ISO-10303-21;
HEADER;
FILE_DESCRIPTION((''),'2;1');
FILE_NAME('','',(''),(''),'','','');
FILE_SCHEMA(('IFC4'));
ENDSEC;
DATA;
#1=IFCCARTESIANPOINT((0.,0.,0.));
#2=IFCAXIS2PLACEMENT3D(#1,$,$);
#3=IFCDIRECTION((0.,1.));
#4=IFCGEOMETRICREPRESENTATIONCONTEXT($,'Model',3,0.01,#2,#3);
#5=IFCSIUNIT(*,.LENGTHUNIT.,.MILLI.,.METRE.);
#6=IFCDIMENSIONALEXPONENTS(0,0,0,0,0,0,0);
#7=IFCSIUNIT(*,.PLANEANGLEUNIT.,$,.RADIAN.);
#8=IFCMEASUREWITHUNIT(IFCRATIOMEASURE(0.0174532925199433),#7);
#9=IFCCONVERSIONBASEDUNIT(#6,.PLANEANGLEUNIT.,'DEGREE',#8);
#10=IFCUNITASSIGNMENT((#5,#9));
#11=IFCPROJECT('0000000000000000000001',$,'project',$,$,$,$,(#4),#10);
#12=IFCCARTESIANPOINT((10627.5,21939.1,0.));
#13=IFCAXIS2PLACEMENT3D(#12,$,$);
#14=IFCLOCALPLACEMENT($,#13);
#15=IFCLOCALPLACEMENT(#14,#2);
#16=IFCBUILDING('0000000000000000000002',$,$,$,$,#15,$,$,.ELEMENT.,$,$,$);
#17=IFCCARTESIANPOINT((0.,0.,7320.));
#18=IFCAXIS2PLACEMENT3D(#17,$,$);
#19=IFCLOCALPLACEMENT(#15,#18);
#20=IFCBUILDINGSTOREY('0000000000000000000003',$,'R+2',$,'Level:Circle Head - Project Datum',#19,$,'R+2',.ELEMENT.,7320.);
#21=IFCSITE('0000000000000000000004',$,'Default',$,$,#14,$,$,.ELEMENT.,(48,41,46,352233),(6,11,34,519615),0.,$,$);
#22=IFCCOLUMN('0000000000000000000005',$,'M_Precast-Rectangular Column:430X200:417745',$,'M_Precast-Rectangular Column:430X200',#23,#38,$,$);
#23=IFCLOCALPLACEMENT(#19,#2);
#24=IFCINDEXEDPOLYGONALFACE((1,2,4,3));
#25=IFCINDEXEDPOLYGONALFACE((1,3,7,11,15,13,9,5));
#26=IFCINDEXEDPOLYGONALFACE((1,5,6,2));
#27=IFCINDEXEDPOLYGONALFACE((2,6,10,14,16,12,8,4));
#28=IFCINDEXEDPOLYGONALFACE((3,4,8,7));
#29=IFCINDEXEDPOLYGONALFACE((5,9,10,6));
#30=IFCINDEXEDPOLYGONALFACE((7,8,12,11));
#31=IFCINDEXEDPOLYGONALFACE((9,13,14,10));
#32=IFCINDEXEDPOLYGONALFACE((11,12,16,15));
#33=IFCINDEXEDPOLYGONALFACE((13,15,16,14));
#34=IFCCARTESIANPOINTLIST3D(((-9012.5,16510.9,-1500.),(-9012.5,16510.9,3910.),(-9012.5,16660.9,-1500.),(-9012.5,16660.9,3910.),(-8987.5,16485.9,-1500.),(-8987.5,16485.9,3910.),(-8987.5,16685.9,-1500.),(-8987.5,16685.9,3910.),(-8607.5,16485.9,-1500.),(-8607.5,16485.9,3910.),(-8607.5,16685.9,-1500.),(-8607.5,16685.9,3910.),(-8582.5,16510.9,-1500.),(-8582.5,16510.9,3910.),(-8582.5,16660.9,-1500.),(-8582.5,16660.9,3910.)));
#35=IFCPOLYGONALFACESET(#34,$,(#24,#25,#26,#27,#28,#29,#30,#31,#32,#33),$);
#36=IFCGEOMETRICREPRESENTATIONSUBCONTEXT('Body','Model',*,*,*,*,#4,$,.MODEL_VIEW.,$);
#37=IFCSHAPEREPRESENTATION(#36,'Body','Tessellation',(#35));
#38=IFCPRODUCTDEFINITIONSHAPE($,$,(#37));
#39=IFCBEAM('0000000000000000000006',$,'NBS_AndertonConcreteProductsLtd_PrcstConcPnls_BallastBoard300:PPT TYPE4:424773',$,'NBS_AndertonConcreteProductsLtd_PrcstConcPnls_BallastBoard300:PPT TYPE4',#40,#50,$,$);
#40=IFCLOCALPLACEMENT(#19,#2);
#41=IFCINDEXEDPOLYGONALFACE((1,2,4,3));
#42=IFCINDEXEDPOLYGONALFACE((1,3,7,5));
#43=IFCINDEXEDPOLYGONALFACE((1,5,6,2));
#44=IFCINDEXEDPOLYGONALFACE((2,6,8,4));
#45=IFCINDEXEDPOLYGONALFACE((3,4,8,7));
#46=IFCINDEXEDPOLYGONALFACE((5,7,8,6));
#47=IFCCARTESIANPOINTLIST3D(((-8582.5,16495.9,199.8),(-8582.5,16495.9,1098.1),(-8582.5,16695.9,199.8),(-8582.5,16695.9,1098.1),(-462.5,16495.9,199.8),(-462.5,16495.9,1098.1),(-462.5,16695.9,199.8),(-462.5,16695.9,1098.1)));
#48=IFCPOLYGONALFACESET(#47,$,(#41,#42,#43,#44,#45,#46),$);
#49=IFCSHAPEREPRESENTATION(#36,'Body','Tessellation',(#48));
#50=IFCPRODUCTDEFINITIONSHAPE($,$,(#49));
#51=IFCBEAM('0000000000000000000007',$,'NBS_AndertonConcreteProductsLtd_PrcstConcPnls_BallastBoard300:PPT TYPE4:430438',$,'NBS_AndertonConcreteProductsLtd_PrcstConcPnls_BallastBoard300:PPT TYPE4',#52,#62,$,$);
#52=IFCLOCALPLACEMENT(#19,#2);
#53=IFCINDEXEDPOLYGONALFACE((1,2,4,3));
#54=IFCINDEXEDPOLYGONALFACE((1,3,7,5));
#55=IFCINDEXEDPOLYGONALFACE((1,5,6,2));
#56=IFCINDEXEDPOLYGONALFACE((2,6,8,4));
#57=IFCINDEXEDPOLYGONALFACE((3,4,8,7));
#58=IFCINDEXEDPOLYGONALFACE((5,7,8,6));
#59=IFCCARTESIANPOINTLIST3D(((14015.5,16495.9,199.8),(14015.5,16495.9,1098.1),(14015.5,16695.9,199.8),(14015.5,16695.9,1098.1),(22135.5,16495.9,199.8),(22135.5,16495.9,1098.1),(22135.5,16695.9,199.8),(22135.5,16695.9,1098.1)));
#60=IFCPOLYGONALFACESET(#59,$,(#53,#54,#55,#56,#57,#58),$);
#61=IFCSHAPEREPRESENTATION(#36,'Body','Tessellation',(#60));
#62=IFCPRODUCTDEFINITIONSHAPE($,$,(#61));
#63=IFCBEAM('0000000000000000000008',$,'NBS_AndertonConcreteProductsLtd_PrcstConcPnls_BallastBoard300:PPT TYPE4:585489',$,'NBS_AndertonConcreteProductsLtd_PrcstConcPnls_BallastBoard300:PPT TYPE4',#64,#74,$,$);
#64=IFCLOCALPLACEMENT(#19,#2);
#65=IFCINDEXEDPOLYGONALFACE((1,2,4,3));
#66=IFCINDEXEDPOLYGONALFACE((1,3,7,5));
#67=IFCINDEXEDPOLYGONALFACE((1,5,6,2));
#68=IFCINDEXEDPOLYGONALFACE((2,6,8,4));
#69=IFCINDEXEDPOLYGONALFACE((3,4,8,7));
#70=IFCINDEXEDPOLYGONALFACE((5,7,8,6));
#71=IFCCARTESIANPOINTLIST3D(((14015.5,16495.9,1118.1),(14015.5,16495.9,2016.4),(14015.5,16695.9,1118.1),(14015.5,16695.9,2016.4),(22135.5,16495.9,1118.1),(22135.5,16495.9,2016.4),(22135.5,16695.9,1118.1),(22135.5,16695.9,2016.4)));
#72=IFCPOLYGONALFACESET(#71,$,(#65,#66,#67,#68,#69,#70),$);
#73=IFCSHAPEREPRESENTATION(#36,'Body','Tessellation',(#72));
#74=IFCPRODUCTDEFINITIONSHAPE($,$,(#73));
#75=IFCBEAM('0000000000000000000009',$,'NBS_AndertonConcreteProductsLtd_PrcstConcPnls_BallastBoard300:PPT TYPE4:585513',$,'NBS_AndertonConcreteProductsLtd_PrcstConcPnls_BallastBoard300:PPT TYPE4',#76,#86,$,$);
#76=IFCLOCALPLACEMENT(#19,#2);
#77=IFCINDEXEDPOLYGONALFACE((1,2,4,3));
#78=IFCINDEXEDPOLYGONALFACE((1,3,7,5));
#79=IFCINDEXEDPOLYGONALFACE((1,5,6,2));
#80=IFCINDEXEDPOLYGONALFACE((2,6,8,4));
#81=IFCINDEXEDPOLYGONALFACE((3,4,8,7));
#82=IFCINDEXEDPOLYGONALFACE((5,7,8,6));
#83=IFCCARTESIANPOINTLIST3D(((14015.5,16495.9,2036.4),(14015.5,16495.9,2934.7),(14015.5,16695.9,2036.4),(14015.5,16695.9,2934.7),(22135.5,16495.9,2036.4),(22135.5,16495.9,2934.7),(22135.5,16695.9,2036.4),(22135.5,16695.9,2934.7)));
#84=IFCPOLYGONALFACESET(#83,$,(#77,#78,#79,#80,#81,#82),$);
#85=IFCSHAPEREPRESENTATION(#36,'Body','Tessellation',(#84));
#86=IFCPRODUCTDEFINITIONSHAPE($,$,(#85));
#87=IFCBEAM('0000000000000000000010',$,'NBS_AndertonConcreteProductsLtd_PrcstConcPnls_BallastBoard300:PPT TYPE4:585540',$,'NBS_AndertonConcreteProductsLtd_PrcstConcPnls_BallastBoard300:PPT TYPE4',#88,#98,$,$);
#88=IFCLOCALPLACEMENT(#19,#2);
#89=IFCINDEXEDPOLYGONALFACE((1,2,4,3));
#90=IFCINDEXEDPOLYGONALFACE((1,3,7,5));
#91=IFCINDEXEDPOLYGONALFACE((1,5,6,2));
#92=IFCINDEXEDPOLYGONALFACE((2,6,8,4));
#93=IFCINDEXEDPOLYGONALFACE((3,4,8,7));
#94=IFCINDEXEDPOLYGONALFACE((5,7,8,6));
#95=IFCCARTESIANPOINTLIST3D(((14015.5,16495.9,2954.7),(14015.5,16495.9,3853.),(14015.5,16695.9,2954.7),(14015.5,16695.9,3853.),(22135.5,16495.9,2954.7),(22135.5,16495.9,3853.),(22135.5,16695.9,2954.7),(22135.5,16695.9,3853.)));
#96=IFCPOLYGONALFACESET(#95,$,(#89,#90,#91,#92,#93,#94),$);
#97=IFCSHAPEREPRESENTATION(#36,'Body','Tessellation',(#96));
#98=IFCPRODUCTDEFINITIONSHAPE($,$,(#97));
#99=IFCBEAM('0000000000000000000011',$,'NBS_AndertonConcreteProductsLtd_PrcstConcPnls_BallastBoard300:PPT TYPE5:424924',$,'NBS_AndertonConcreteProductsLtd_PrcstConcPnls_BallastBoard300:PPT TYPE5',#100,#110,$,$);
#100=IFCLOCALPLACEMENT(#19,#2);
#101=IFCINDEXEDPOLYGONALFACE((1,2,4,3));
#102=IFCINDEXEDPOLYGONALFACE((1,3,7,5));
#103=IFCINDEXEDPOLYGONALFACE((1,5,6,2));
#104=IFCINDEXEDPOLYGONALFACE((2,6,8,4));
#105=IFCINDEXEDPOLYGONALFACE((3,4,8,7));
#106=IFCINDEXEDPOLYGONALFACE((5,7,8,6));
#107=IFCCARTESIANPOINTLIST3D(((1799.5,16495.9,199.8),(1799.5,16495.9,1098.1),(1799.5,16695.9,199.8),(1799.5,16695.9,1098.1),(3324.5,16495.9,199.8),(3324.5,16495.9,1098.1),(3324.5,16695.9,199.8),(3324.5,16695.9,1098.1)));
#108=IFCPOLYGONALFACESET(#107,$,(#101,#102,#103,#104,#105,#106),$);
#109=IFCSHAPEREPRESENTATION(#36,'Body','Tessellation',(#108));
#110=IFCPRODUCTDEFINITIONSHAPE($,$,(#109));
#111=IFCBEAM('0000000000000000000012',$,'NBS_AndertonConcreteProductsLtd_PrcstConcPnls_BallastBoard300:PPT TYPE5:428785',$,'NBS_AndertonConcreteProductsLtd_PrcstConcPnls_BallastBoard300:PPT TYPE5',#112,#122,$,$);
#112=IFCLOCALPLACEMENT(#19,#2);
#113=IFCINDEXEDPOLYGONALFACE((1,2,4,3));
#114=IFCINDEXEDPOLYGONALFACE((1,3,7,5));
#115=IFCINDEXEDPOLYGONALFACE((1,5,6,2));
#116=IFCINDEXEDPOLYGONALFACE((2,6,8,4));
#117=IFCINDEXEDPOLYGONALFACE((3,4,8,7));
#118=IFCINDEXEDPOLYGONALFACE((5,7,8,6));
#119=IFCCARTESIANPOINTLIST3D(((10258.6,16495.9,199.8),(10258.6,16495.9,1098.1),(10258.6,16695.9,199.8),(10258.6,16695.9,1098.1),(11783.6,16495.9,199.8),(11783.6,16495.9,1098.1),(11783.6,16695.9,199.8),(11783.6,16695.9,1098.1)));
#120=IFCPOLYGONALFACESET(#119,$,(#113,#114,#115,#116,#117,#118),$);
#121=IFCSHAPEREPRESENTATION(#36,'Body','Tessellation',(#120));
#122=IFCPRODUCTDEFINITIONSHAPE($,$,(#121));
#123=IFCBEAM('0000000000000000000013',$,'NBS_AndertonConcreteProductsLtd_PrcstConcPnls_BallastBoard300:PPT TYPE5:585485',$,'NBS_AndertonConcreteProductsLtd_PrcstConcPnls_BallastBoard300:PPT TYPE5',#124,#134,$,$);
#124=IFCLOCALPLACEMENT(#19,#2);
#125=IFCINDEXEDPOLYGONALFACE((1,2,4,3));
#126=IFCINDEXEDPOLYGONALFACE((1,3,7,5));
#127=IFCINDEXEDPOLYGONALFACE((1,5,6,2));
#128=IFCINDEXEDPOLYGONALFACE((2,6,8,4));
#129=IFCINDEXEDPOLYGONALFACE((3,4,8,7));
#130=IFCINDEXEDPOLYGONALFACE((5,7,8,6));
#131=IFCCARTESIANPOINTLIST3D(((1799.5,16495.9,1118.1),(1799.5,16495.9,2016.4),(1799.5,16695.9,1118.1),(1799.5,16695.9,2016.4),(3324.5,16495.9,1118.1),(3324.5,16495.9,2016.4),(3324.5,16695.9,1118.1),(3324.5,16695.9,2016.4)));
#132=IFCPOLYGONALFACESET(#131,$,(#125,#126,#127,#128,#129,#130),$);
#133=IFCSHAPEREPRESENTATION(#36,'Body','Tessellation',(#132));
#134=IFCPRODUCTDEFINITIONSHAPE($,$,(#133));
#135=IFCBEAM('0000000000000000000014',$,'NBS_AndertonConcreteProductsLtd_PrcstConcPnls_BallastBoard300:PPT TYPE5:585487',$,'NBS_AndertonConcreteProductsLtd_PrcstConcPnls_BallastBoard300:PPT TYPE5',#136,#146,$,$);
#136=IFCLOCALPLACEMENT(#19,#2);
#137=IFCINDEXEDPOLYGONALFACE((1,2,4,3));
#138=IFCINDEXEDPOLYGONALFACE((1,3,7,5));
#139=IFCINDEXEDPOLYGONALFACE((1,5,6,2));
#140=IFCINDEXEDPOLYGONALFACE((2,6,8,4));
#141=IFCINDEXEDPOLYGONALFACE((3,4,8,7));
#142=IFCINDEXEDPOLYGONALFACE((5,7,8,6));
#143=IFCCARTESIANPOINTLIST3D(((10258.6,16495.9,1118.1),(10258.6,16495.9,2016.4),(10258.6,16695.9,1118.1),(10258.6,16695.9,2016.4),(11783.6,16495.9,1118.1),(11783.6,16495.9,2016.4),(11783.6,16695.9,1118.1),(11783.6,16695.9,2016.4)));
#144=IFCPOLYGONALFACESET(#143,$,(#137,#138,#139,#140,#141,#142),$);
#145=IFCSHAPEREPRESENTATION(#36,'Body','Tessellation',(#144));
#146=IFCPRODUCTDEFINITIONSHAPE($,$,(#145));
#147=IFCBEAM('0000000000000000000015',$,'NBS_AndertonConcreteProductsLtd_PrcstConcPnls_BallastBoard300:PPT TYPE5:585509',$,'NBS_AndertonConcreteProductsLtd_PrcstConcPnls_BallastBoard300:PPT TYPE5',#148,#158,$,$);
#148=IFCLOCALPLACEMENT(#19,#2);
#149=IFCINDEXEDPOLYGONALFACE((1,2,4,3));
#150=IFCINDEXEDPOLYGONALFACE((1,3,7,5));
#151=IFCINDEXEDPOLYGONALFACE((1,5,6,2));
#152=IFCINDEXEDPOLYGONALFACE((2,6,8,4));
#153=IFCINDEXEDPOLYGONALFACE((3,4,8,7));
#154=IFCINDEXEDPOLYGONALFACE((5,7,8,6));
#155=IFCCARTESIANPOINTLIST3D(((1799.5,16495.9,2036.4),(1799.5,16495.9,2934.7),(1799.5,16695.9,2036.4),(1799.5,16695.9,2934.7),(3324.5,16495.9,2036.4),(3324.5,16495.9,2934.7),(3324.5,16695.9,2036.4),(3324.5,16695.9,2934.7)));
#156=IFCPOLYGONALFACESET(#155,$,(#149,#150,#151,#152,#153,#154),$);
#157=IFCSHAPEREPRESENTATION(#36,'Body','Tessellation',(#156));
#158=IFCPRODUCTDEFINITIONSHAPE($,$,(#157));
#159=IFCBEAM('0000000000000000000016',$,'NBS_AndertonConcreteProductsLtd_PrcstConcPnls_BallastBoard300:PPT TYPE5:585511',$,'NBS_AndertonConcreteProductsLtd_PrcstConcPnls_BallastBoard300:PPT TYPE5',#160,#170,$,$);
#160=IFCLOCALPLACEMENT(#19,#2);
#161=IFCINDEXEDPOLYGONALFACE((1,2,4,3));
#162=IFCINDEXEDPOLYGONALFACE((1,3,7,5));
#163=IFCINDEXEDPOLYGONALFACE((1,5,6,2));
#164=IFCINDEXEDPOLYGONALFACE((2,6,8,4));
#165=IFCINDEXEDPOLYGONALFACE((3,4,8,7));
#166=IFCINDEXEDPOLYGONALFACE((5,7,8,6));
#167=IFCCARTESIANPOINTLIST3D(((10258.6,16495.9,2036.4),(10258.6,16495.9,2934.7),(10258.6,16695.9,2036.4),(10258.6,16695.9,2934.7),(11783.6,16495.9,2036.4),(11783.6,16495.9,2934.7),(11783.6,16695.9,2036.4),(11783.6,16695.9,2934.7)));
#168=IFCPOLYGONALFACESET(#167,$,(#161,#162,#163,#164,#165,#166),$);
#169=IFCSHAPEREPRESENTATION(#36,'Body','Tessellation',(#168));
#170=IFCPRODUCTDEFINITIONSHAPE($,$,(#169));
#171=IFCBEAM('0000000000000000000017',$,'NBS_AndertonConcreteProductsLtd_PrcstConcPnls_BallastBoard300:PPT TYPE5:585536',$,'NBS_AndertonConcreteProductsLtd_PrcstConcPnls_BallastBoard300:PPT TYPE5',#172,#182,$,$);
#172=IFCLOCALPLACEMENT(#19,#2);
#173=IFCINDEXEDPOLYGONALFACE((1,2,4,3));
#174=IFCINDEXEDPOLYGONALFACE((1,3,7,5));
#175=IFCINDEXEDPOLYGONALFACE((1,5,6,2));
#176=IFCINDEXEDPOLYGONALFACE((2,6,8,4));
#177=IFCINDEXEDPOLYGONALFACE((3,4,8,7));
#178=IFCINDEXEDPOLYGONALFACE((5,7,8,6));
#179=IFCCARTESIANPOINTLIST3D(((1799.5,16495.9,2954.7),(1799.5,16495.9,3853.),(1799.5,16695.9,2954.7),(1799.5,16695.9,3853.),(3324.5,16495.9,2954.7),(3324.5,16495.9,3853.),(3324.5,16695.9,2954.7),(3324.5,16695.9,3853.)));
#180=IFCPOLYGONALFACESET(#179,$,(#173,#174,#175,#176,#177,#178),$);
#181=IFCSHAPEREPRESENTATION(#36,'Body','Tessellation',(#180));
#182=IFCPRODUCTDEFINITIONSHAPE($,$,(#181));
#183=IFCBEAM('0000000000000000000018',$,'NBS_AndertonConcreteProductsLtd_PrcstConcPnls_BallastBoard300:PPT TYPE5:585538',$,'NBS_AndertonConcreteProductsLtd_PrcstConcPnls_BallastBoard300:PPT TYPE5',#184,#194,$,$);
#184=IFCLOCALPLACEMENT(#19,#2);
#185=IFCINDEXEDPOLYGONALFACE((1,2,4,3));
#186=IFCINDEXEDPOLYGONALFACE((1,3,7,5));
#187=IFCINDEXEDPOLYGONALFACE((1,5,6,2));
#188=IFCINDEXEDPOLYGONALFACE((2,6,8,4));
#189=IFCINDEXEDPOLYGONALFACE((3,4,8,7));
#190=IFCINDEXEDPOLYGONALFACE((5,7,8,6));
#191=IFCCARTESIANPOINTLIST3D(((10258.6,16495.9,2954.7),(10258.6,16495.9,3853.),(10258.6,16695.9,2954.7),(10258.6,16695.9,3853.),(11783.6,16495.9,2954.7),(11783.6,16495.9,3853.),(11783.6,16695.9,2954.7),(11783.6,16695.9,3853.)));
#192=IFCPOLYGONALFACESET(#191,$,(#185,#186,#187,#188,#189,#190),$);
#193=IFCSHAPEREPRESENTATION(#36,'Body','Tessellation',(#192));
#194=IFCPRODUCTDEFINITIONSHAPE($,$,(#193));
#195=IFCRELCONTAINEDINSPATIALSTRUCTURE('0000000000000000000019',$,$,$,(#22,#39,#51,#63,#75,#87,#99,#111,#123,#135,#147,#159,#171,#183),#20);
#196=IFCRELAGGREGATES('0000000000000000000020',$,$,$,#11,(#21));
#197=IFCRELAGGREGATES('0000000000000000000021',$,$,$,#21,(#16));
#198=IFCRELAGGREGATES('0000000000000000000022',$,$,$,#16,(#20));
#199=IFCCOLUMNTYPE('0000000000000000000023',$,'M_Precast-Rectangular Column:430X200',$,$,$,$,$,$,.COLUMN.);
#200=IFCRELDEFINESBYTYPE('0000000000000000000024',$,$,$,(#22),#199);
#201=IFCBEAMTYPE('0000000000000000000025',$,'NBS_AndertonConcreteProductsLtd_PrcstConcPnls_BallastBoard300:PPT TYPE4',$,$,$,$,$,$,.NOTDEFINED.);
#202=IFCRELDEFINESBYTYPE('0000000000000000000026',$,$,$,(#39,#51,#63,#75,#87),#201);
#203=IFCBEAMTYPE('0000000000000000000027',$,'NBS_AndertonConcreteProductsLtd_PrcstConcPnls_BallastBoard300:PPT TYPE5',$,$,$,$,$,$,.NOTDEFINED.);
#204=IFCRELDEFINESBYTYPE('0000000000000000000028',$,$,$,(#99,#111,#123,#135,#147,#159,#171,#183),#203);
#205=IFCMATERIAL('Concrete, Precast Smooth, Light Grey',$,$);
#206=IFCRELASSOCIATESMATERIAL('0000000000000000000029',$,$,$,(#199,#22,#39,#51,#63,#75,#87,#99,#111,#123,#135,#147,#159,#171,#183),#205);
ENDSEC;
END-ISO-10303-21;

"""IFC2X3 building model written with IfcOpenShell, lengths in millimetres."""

from ifc_helpers import new_model, entity, si_unit, converted_unit, direction, frame, frame_2d, origin, place, context, subcontext, project, spatial, polyline, rectangle, outline, extrude, source, transform, mapped, material, type_object, type_shapes, element, save


model = new_model("IFC2X3")

# Units and contexts
model_context = context("Model", 3, precision=0.01, world=origin(), true_north=direction((0.0, 1.0)))
body_context = subcontext(model_context, "Body", "Model", "MODEL_VIEW")
ifc_project = project(units=[si_unit("LENGTHUNIT", "METRE", prefix="MILLI"), converted_unit("PLANEANGLEUNIT", "DEGREE", entity("IfcRatioMeasure", 0.0174532925199433), si_unit("PLANEANGLEUNIT", "RADIAN"), dimensions=[0, 0, 0, 0, 0, 0, 0])], contexts=[model_context])

# Site, building, storey
site_placement = place(None, frame((10627.5, 21939.1, 0.0)))
site = spatial("IfcSite", under=ifc_project, at=site_placement, Name="Default", CompositionType="ELEMENT", RefLatitude=(48, 41, 46, 352233), RefLongitude=(6, 11, 34, 519615), RefElevation=0.0)
building_placement = place(site_placement, origin())
building = spatial("IfcBuilding", under=site, at=building_placement, CompositionType="ELEMENT")
storey_placement = place(building_placement, frame((0.0, 0.0, 7320.0)))
storey = spatial("IfcBuildingStorey", under=building, at=storey_placement, Name="R+2", ObjectType="Level:Circle Head - Project Datum", LongName="R+2", CompositionType="ELEMENT", Elevation=7320.0)

# Column
ifc_material = material(Name="Concrete, Precast Smooth, Light Grey")
column_type_1 = type_object("IfcColumnType", Name="M_Precast-Rectangular Column:430X200", PredefinedType="COLUMN", material=ifc_material)
shared_shape_1 = source(origin(), body_context, "Body", "SweptSolid", [
    extrude(outline(polyline([(-75.0, -215.0), (75.0, -215.0), (100.0, -190.0), (100.0, 190.0), (75.0, 215.0), (-75.0, 215.0), (-100.0, 190.0), (-100.0, -190.0), (-75.0, -215.0)])), frame((0.0, 0.0, 5820.0), z_axis=(0.0, 0.0, 1.0), x_axis=(0.0, -1.0, 0.0)), (0.0, 0.0, 1.0), 5410.0),
])
type_shapes(column_type_1, [shared_shape_1])
column_1_placement = place(storey_placement, frame((-8797.5, 16585.9, -7320.0), z_axis=(0.0, 0.0, 1.0), x_axis=(-1.0, 0.0, 0.0)))
element("IfcColumn", 1, at=column_1_placement, inside=storey, type_object=column_type_1, material=ifc_material, Name="M_Precast-Rectangular Column:430X200:417745", ObjectType="M_Precast-Rectangular Column:430X200", context=body_context, shape_type="MappedRepresentation", body=[
    mapped(shared_shape_1, transform((0.0, 0.0, 0.0), scale=1.0)),
])

# Beams
beam_type_1 = type_object("IfcBeamType", Name="NBS_AndertonConcreteProductsLtd_PrcstConcPnls_BallastBoard300:PPT TYPE4", PredefinedType="NOTDEFINED")
beam_1_placement = place(storey_placement, origin())
element("IfcBeam", 2, at=beam_1_placement, inside=storey, type_object=beam_type_1, material=ifc_material, Name="NBS_AndertonConcreteProductsLtd_PrcstConcPnls_BallastBoard300:PPT TYPE4:424773", ObjectType="NBS_AndertonConcreteProductsLtd_PrcstConcPnls_BallastBoard300:PPT TYPE4", context=body_context, shape_type="SweptSolid", body=[
    extrude(rectangle(XDim=898.3, YDim=200.0, at=frame_2d((0.0, 0.0), x_axis=(0.0, 1.0))), frame((-8582.5, 16595.9, 649.0), z_axis=(1.0, 0.0, 0.0), x_axis=(0.0, 1.0, 0.0)), (0.0, 0.0, 1.0), 8120.0),
])
beam_2_placement = place(storey_placement, origin())
element("IfcBeam", 3, at=beam_2_placement, inside=storey, type_object=beam_type_1, material=ifc_material, Name="NBS_AndertonConcreteProductsLtd_PrcstConcPnls_BallastBoard300:PPT TYPE4:430438", ObjectType="NBS_AndertonConcreteProductsLtd_PrcstConcPnls_BallastBoard300:PPT TYPE4", context=body_context, shape_type="SweptSolid", body=[
    extrude(rectangle(XDim=898.3, YDim=200.0, at=frame_2d((0.0, 0.0), x_axis=(0.0, 1.0))), frame((14015.5, 16595.9, 649.0), z_axis=(1.0, 0.0, 0.0), x_axis=(0.0, 1.0, 0.0)), (0.0, 0.0, 1.0), 8120.0),
])
beam_3_placement = place(storey_placement, origin())
element("IfcBeam", 4, at=beam_3_placement, inside=storey, type_object=beam_type_1, material=ifc_material, Name="NBS_AndertonConcreteProductsLtd_PrcstConcPnls_BallastBoard300:PPT TYPE4:585489", ObjectType="NBS_AndertonConcreteProductsLtd_PrcstConcPnls_BallastBoard300:PPT TYPE4", context=body_context, shape_type="SweptSolid", body=[
    extrude(rectangle(XDim=898.3, YDim=200.0, at=frame_2d((0.0, 0.0), x_axis=(0.0, 1.0))), frame((14015.5, 16595.9, 1567.3), z_axis=(1.0, 0.0, 0.0), x_axis=(0.0, 1.0, 0.0)), (0.0, 0.0, 1.0), 8120.0),
])
beam_4_placement = place(storey_placement, origin())
element("IfcBeam", 5, at=beam_4_placement, inside=storey, type_object=beam_type_1, material=ifc_material, Name="NBS_AndertonConcreteProductsLtd_PrcstConcPnls_BallastBoard300:PPT TYPE4:585513", ObjectType="NBS_AndertonConcreteProductsLtd_PrcstConcPnls_BallastBoard300:PPT TYPE4", context=body_context, shape_type="SweptSolid", body=[
    extrude(rectangle(XDim=898.3, YDim=200.0, at=frame_2d((0.0, 0.0), x_axis=(0.0, 1.0))), frame((14015.5, 16595.9, 2485.6), z_axis=(1.0, 0.0, 0.0), x_axis=(0.0, 1.0, 0.0)), (0.0, 0.0, 1.0), 8120.0),
])
beam_5_placement = place(storey_placement, origin())
element("IfcBeam", 6, at=beam_5_placement, inside=storey, type_object=beam_type_1, material=ifc_material, Name="NBS_AndertonConcreteProductsLtd_PrcstConcPnls_BallastBoard300:PPT TYPE4:585540", ObjectType="NBS_AndertonConcreteProductsLtd_PrcstConcPnls_BallastBoard300:PPT TYPE4", context=body_context, shape_type="SweptSolid", body=[
    extrude(rectangle(XDim=898.3, YDim=200.0, at=frame_2d((0.0, 0.0), x_axis=(0.0, 1.0))), frame((14015.5, 16595.9, 3403.9), z_axis=(1.0, 0.0, 0.0), x_axis=(0.0, 1.0, 0.0)), (0.0, 0.0, 1.0), 8120.0),
])
beam_type_2 = type_object("IfcBeamType", Name="NBS_AndertonConcreteProductsLtd_PrcstConcPnls_BallastBoard300:PPT TYPE5", PredefinedType="NOTDEFINED")
beam_6_placement = place(storey_placement, origin())
element("IfcBeam", 7, at=beam_6_placement, inside=storey, type_object=beam_type_2, material=ifc_material, Name="NBS_AndertonConcreteProductsLtd_PrcstConcPnls_BallastBoard300:PPT TYPE5:424924", ObjectType="NBS_AndertonConcreteProductsLtd_PrcstConcPnls_BallastBoard300:PPT TYPE5", context=body_context, shape_type="SweptSolid", body=[
    extrude(rectangle(XDim=898.3, YDim=200.0, at=frame_2d((0.0, 0.0), x_axis=(0.0, 1.0))), frame((1799.5, 16595.9, 649.0), z_axis=(1.0, 0.0, 0.0), x_axis=(0.0, 1.0, 0.0)), (0.0, 0.0, 1.0), 1525.0),
])
beam_7_placement = place(storey_placement, origin())
element("IfcBeam", 8, at=beam_7_placement, inside=storey, type_object=beam_type_2, material=ifc_material, Name="NBS_AndertonConcreteProductsLtd_PrcstConcPnls_BallastBoard300:PPT TYPE5:428785", ObjectType="NBS_AndertonConcreteProductsLtd_PrcstConcPnls_BallastBoard300:PPT TYPE5", context=body_context, shape_type="SweptSolid", body=[
    extrude(rectangle(XDim=898.3, YDim=200.0, at=frame_2d((0.0, 0.0), x_axis=(0.0, 1.0))), frame((10258.6, 16595.9, 649.0), z_axis=(1.0, 0.0, 0.0), x_axis=(0.0, 1.0, 0.0)), (0.0, 0.0, 1.0), 1525.0),
])
beam_8_placement = place(storey_placement, origin())
element("IfcBeam", 9, at=beam_8_placement, inside=storey, type_object=beam_type_2, material=ifc_material, Name="NBS_AndertonConcreteProductsLtd_PrcstConcPnls_BallastBoard300:PPT TYPE5:585485", ObjectType="NBS_AndertonConcreteProductsLtd_PrcstConcPnls_BallastBoard300:PPT TYPE5", context=body_context, shape_type="SweptSolid", body=[
    extrude(rectangle(XDim=898.3, YDim=200.0, at=frame_2d((0.0, 0.0), x_axis=(0.0, 1.0))), frame((1799.5, 16595.9, 1567.3), z_axis=(1.0, 0.0, 0.0), x_axis=(0.0, 1.0, 0.0)), (0.0, 0.0, 1.0), 1525.0),
])
beam_9_placement = place(storey_placement, origin())
element("IfcBeam", 10, at=beam_9_placement, inside=storey, type_object=beam_type_2, material=ifc_material, Name="NBS_AndertonConcreteProductsLtd_PrcstConcPnls_BallastBoard300:PPT TYPE5:585487", ObjectType="NBS_AndertonConcreteProductsLtd_PrcstConcPnls_BallastBoard300:PPT TYPE5", context=body_context, shape_type="SweptSolid", body=[
    extrude(rectangle(XDim=898.3, YDim=200.0, at=frame_2d((0.0, 0.0), x_axis=(0.0, 1.0))), frame((10258.6, 16595.9, 1567.3), z_axis=(1.0, 0.0, 0.0), x_axis=(0.0, 1.0, 0.0)), (0.0, 0.0, 1.0), 1525.0),
])
beam_10_placement = place(storey_placement, origin())
element("IfcBeam", 11, at=beam_10_placement, inside=storey, type_object=beam_type_2, material=ifc_material, Name="NBS_AndertonConcreteProductsLtd_PrcstConcPnls_BallastBoard300:PPT TYPE5:585509", ObjectType="NBS_AndertonConcreteProductsLtd_PrcstConcPnls_BallastBoard300:PPT TYPE5", context=body_context, shape_type="SweptSolid", body=[
    extrude(rectangle(XDim=898.3, YDim=200.0, at=frame_2d((0.0, 0.0), x_axis=(0.0, 1.0))), frame((1799.5, 16595.9, 2485.6), z_axis=(1.0, 0.0, 0.0), x_axis=(0.0, 1.0, 0.0)), (0.0, 0.0, 1.0), 1525.0),
])
beam_11_placement = place(storey_placement, origin())
element("IfcBeam", 12, at=beam_11_placement, inside=storey, type_object=beam_type_2, material=ifc_material, Name="NBS_AndertonConcreteProductsLtd_PrcstConcPnls_BallastBoard300:PPT TYPE5:585511", ObjectType="NBS_AndertonConcreteProductsLtd_PrcstConcPnls_BallastBoard300:PPT TYPE5", context=body_context, shape_type="SweptSolid", body=[
    extrude(rectangle(XDim=898.3, YDim=200.0, at=frame_2d((0.0, 0.0), x_axis=(0.0, 1.0))), frame((10258.6, 16595.9, 2485.6), z_axis=(1.0, 0.0, 0.0), x_axis=(0.0, 1.0, 0.0)), (0.0, 0.0, 1.0), 1525.0),
])
beam_12_placement = place(storey_placement, origin())
element("IfcBeam", 13, at=beam_12_placement, inside=storey, type_object=beam_type_2, material=ifc_material, Name="NBS_AndertonConcreteProductsLtd_PrcstConcPnls_BallastBoard300:PPT TYPE5:585536", ObjectType="NBS_AndertonConcreteProductsLtd_PrcstConcPnls_BallastBoard300:PPT TYPE5", context=body_context, shape_type="SweptSolid", body=[
    extrude(rectangle(XDim=898.3, YDim=200.0, at=frame_2d((0.0, 0.0), x_axis=(0.0, 1.0))), frame((1799.5, 16595.9, 3403.9), z_axis=(1.0, 0.0, 0.0), x_axis=(0.0, 1.0, 0.0)), (0.0, 0.0, 1.0), 1525.0),
])
beam_13_placement = place(storey_placement, origin())
element("IfcBeam", 14, at=beam_13_placement, inside=storey, type_object=beam_type_2, material=ifc_material, Name="NBS_AndertonConcreteProductsLtd_PrcstConcPnls_BallastBoard300:PPT TYPE5:585538", ObjectType="NBS_AndertonConcreteProductsLtd_PrcstConcPnls_BallastBoard300:PPT TYPE5", context=body_context, shape_type="SweptSolid", body=[
    extrude(rectangle(XDim=898.3, YDim=200.0, at=frame_2d((0.0, 0.0), x_axis=(0.0, 1.0))), frame((10258.6, 16595.9, 3403.9), z_axis=(1.0, 0.0, 0.0), x_axis=(0.0, 1.0, 0.0)), (0.0, 0.0, 1.0), 1525.0),
])

save(model, "model.ifc")
